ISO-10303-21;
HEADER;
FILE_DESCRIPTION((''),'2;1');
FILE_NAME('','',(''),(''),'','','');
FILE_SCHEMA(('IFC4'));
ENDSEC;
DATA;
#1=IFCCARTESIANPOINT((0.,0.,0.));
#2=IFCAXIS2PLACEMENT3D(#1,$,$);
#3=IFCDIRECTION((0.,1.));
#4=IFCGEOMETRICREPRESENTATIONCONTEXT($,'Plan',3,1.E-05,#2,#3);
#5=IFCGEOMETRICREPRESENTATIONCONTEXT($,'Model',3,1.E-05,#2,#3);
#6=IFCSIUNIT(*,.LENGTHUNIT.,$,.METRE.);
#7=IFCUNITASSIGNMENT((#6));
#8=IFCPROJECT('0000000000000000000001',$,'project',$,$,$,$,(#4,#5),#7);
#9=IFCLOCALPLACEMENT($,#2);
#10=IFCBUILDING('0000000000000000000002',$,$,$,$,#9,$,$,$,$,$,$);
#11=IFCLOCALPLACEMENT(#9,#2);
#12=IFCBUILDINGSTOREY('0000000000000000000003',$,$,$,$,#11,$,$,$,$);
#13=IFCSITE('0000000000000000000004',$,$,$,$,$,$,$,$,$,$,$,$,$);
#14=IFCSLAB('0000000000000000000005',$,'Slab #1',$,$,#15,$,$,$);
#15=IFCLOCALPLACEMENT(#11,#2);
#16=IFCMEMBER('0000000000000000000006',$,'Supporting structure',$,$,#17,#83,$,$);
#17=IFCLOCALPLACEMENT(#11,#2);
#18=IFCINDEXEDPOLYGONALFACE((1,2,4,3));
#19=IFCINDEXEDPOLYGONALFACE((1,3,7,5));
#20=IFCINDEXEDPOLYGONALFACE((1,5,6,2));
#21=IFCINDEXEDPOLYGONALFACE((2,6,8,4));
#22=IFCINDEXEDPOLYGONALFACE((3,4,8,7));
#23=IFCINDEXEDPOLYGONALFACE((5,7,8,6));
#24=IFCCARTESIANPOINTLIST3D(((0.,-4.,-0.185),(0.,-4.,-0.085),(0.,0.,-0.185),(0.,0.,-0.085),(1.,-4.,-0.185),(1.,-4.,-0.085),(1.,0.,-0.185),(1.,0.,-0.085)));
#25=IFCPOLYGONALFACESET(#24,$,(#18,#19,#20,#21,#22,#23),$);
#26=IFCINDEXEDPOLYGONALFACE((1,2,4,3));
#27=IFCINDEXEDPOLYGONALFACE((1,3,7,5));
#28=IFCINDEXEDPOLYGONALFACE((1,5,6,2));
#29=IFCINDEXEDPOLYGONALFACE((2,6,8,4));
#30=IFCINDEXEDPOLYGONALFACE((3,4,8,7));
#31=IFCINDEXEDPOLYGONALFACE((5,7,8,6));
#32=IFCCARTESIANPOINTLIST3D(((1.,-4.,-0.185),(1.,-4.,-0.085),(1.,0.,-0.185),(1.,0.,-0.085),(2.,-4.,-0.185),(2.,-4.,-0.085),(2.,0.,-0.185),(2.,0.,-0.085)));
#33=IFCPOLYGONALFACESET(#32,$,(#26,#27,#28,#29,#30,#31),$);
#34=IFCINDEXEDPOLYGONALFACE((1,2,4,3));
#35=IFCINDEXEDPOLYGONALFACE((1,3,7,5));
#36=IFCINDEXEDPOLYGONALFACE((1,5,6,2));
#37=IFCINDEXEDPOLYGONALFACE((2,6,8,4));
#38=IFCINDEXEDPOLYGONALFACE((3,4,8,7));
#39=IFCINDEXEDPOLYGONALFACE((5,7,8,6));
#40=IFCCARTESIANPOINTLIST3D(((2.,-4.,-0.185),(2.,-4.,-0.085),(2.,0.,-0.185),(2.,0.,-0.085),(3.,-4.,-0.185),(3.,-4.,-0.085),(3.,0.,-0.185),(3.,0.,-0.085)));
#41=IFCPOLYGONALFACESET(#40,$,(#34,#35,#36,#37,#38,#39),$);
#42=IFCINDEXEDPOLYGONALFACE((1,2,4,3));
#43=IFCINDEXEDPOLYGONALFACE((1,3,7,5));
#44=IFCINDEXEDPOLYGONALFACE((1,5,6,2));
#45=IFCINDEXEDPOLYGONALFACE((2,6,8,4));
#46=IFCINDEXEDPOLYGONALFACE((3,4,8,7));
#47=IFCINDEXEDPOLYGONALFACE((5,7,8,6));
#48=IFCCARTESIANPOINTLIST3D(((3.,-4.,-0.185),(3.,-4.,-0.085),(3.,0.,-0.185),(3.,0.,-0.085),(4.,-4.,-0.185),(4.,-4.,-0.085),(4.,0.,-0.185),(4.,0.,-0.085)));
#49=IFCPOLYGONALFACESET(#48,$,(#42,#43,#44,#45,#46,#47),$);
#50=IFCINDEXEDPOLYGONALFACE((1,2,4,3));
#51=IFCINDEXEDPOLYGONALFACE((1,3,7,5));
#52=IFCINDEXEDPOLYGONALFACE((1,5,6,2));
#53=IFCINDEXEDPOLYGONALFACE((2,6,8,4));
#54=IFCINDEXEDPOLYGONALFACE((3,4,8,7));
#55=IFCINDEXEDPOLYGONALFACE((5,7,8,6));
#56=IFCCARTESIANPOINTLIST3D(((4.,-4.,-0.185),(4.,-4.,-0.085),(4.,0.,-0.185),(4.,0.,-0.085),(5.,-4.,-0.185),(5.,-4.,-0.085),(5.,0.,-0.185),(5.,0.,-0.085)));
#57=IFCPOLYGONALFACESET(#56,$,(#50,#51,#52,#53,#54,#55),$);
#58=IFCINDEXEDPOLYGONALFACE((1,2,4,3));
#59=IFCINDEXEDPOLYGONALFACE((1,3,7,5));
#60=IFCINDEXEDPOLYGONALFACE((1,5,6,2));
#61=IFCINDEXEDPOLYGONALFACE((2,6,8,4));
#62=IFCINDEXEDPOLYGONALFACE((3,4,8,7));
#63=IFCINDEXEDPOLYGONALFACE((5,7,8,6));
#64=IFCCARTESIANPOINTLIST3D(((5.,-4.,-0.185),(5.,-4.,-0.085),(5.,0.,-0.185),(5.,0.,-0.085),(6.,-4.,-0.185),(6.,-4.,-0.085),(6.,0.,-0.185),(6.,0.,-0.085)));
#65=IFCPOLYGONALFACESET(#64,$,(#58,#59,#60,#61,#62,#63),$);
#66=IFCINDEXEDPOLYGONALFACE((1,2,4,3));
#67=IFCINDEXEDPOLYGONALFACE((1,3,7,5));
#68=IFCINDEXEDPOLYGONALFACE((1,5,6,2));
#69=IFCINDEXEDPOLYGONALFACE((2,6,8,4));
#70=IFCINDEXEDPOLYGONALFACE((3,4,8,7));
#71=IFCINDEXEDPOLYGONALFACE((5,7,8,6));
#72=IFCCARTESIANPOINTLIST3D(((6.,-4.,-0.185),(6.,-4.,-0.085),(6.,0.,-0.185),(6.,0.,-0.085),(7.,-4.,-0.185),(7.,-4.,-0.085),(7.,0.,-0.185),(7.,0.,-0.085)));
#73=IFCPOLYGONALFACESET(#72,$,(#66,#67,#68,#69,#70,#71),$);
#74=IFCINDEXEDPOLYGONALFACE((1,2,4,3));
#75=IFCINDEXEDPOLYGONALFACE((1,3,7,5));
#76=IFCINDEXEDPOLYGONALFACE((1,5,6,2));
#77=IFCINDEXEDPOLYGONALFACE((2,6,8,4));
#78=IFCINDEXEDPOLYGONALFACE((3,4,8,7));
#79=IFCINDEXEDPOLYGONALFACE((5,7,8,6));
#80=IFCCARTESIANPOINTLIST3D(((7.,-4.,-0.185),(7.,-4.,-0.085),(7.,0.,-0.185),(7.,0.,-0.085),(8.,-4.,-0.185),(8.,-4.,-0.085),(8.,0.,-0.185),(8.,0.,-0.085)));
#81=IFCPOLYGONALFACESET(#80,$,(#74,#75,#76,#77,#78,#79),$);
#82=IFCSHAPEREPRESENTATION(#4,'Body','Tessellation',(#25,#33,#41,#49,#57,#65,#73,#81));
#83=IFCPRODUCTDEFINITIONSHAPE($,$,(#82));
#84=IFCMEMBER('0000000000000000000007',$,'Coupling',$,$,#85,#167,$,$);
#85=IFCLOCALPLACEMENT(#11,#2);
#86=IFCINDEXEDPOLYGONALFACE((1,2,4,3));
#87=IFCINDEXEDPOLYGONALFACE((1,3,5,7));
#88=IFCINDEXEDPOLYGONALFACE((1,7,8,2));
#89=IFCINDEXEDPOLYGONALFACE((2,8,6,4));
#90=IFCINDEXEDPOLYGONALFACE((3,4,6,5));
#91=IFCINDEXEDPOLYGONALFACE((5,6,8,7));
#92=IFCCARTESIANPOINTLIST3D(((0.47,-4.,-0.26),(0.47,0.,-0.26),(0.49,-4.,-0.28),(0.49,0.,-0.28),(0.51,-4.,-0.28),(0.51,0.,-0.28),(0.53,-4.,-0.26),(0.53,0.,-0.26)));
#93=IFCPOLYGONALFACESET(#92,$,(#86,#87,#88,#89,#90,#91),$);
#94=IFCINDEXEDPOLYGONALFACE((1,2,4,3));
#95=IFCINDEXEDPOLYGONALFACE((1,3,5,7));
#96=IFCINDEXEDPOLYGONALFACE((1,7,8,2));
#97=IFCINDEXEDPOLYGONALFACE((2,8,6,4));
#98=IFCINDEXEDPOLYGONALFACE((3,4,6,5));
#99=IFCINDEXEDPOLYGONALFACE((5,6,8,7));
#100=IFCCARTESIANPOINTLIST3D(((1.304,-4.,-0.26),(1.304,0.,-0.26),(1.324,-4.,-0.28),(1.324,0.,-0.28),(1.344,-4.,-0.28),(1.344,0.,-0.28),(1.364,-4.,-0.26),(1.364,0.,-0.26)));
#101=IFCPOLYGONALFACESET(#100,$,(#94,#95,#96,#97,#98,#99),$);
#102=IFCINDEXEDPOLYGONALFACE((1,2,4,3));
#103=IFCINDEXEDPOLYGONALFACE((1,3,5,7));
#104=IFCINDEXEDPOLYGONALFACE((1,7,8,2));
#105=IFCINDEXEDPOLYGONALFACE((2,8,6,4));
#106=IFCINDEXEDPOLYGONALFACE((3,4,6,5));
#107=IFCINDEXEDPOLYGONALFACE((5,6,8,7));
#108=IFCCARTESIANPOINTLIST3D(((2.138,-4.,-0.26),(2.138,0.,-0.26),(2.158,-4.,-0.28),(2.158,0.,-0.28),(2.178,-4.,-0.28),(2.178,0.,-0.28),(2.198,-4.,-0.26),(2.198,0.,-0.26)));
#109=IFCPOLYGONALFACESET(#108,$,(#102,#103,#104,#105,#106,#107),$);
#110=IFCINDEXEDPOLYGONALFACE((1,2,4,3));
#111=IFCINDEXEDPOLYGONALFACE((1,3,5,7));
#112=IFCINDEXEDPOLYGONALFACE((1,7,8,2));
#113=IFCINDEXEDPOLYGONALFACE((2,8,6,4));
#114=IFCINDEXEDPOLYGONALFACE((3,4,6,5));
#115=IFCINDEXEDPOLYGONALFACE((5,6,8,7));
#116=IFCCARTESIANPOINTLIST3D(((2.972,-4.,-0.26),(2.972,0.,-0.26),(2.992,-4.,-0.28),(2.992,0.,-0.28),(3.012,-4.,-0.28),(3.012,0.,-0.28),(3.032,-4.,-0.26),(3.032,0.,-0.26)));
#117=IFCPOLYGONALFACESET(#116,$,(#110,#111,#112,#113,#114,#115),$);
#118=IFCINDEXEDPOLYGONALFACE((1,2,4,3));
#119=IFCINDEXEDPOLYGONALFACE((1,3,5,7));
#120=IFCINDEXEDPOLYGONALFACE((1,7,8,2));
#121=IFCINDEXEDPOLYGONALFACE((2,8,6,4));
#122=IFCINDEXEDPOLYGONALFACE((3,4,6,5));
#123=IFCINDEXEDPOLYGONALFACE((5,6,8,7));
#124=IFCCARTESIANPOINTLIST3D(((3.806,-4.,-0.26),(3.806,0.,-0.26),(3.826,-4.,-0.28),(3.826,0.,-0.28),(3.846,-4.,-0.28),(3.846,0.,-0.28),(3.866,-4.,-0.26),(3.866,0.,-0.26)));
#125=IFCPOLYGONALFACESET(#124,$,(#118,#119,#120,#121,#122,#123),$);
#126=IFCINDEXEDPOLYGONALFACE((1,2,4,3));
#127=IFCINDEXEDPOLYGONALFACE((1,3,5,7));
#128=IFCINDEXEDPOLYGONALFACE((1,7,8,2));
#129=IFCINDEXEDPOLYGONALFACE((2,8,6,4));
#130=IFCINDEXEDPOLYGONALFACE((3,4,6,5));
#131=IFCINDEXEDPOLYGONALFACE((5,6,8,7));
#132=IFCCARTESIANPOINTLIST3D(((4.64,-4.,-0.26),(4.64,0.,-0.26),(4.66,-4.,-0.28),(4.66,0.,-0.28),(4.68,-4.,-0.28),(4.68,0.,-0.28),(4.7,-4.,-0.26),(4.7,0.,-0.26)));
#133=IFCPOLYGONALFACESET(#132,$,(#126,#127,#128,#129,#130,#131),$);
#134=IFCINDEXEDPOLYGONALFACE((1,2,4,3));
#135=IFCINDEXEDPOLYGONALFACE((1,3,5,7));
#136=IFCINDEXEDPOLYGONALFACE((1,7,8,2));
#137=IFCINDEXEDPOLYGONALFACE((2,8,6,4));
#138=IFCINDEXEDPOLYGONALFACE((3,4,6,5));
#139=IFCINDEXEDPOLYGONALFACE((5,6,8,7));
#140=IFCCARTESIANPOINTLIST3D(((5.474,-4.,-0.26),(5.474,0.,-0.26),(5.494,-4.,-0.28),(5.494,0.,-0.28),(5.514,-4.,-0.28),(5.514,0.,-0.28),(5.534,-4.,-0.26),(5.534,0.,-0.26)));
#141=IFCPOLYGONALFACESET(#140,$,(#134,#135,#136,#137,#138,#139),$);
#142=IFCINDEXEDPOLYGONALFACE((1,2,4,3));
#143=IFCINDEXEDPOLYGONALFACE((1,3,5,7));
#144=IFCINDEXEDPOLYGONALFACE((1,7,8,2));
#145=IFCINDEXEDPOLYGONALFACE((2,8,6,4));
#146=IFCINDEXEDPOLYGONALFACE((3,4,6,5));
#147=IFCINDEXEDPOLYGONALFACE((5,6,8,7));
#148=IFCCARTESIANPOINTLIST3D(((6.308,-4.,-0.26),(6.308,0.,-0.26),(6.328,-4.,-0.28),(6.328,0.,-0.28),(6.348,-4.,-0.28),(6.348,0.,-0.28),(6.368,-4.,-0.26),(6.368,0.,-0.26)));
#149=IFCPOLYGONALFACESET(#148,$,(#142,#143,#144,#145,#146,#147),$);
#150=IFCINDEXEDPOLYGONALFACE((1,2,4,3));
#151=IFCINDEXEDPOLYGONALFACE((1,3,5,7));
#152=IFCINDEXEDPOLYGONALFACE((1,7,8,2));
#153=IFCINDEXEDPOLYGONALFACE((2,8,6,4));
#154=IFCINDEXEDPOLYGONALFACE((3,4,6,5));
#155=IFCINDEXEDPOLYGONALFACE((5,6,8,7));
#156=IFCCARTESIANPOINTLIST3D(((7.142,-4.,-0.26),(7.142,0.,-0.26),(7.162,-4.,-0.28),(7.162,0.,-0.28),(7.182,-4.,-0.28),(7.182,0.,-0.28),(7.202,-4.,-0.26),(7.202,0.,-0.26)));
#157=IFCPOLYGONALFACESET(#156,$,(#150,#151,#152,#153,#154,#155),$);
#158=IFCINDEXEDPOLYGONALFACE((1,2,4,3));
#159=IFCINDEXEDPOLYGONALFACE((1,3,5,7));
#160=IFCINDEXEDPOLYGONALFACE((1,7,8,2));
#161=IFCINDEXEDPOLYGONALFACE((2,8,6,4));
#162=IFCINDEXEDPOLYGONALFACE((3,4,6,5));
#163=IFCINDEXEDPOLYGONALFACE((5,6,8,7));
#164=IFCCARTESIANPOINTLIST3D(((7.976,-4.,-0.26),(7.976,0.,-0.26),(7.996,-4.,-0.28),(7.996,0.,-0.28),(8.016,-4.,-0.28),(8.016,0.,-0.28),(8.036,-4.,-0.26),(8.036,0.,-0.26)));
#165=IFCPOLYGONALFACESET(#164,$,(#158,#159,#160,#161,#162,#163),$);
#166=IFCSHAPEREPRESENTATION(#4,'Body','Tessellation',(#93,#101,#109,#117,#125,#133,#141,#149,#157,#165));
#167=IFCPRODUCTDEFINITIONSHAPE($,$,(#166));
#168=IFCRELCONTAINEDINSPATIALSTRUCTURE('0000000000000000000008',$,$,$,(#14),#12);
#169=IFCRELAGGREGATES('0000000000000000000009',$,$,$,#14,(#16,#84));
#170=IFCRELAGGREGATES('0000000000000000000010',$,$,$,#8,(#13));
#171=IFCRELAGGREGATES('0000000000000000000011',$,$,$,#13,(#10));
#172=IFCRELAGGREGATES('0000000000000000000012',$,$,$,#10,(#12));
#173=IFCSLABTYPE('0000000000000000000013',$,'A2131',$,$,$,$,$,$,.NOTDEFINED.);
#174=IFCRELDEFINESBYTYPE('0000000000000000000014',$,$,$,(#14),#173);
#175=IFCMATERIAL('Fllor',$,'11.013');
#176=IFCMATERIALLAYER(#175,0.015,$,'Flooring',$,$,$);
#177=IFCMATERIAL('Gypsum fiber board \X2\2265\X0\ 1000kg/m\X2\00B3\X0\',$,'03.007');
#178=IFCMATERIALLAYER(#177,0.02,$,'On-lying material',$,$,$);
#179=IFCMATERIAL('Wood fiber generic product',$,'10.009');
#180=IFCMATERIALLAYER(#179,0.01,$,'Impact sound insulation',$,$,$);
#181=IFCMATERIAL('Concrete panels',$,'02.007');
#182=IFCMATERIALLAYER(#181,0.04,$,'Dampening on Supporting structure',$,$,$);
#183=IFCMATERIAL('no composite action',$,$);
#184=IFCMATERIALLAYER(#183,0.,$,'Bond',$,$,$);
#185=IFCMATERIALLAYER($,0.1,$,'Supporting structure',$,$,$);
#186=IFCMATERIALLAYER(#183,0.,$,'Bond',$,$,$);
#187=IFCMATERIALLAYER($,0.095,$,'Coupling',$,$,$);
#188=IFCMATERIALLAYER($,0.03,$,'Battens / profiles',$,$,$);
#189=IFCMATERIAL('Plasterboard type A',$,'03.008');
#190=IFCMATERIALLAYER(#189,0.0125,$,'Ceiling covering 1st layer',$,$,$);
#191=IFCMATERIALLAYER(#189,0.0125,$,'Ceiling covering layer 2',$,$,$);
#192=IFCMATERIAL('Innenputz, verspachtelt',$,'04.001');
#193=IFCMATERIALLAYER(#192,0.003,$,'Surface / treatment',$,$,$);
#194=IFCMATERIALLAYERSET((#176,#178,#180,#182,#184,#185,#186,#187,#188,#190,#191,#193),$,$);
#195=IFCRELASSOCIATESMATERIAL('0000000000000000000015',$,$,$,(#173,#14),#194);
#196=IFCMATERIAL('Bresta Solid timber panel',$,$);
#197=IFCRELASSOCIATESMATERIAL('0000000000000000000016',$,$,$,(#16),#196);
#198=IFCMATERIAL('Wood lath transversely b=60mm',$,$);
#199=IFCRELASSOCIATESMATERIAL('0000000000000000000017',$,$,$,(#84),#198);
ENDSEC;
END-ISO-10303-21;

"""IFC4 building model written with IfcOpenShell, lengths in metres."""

from ifc_helpers import new_model, si_unit, direction, frame, frame_2d, origin, place, context, project, spatial, polyline, rectangle, outline, extrude, material, layer, layer_set, type_object, element, aggregate, save


model = new_model("IFC4")

# Units and contexts
plan_context = context("Plan", 3, precision=1e-05, world=origin(), true_north=direction((0.0, 1.0)))
model_context = context("Model", 3, precision=1e-05, world=origin(), true_north=direction((0.0, 1.0)))
ifc_project = project(units=[si_unit("LENGTHUNIT", "METRE")], contexts=[plan_context, model_context])

# Site, building, storey
site = spatial("IfcSite", under=ifc_project)
building_placement = place(None, origin())
building = spatial("IfcBuilding", under=site, at=building_placement)
storey_placement = place(building_placement, origin())
storey = spatial("IfcBuildingStorey", under=building, at=storey_placement)

# Slab, members
ifc_material_1 = material(Name="Fllor", Category="11.013")
ifc_layer_1 = layer(ifc_material_1, 0.015, Name="Flooring")
ifc_material_2 = material(Name="Gypsum fiber board ≥ 1000kg/m³", Category="03.007")
ifc_layer_2 = layer(ifc_material_2, 0.02, Name="On-lying material")
ifc_material_3 = material(Name="Wood fiber generic product", Category="10.009")
ifc_layer_3 = layer(ifc_material_3, 0.01, Name="Impact sound insulation")
ifc_material_4 = material(Name="Concrete panels", Category="02.007")
ifc_layer_4 = layer(ifc_material_4, 0.04, Name="Dampening on Supporting structure")
ifc_material_5 = material(Name="no composite action")
ifc_layer_5 = layer(ifc_material_5, 0.0, Name="Bond")
ifc_layer_6 = layer(None, 0.1, Name="Supporting structure")
ifc_layer_7 = layer(ifc_material_5, 0.0, Name="Bond")
ifc_layer_8 = layer(None, 0.095, Name="Coupling")
ifc_layer_9 = layer(None, 0.03, Name="Battens / profiles")
ifc_material_6 = material(Name="Plasterboard type A", Category="03.008")
ifc_layer_10 = layer(ifc_material_6, 0.0125, Name="Ceiling covering 1st layer")
ifc_layer_11 = layer(ifc_material_6, 0.0125, Name="Ceiling covering layer 2")
ifc_material_7 = material(Name="Innenputz, verspachtelt", Category="04.001")
ifc_layer_12 = layer(ifc_material_7, 0.003, Name="Surface / treatment")
ifc_layer_set = layer_set([ifc_layer_1, ifc_layer_2, ifc_layer_3, ifc_layer_4, ifc_layer_5, ifc_layer_6, ifc_layer_7, ifc_layer_8, ifc_layer_9, ifc_layer_10, ifc_layer_11, ifc_layer_12])
slab_type = type_object("IfcSlabType", Name="A2131", PredefinedType="NOTDEFINED", material=ifc_layer_set)
slab_placement = place(None, frame((0.0, 0.0, 0.0), z_axis=(0.0, 0.0, -1.0), x_axis=(1.0, 0.0, 0.0)))
slab = element("IfcSlab", 1, at=slab_placement, inside=storey, type_object=slab_type, material=ifc_layer_set, Name="Slab #1")
ifc_material_8 = material(Name="Bresta Solid timber panel")
member_1_placement = place(slab_placement, origin())
member_1 = element("IfcMember", 2, at=member_1_placement, material=ifc_material_8, Name="Supporting structure", context=plan_context, shape_type="SweptSolid", body=[
    extrude(rectangle(XDim=1.0, YDim=0.1, at=frame_2d((0.5, 0.05), x_axis=(1.0, 0.0))), frame((0.0, 4.0, 0.085), z_axis=(0.0, -1.0, 0.0), x_axis=(1.0, 0.0, 0.0)), (0.0, 0.0, 1.0), 4.0),
    extrude(rectangle(XDim=1.0, YDim=0.1, at=frame_2d((0.5, 0.05), x_axis=(1.0, 0.0))), frame((1.0, 4.0, 0.085), z_axis=(0.0, -1.0, 0.0), x_axis=(1.0, 0.0, 0.0)), (0.0, 0.0, 1.0), 4.0),
    extrude(rectangle(XDim=1.0, YDim=0.1, at=frame_2d((0.5, 0.05), x_axis=(1.0, 0.0))), frame((2.0, 4.0, 0.085), z_axis=(0.0, -1.0, 0.0), x_axis=(1.0, 0.0, 0.0)), (0.0, 0.0, 1.0), 4.0),
    extrude(rectangle(XDim=1.0, YDim=0.1, at=frame_2d((0.5, 0.05), x_axis=(1.0, 0.0))), frame((3.0, 4.0, 0.085), z_axis=(0.0, -1.0, 0.0), x_axis=(1.0, 0.0, 0.0)), (0.0, 0.0, 1.0), 4.0),
    extrude(rectangle(XDim=1.0, YDim=0.1, at=frame_2d((0.5, 0.05), x_axis=(1.0, 0.0))), frame((4.0, 4.0, 0.085), z_axis=(0.0, -1.0, 0.0), x_axis=(1.0, 0.0, 0.0)), (0.0, 0.0, 1.0), 4.0),
    extrude(rectangle(XDim=1.0, YDim=0.1, at=frame_2d((0.5, 0.05), x_axis=(1.0, 0.0))), frame((5.0, 4.0, 0.085), z_axis=(0.0, -1.0, 0.0), x_axis=(1.0, 0.0, 0.0)), (0.0, 0.0, 1.0), 4.0),
    extrude(rectangle(XDim=1.0, YDim=0.1, at=frame_2d((0.5, 0.05), x_axis=(1.0, 0.0))), frame((6.0, 4.0, 0.085), z_axis=(0.0, -1.0, 0.0), x_axis=(1.0, 0.0, 0.0)), (0.0, 0.0, 1.0), 4.0),
    extrude(rectangle(XDim=1.0, YDim=0.1, at=frame_2d((0.5, 0.05), x_axis=(1.0, 0.0))), frame((7.0, 4.0, 0.085), z_axis=(0.0, -1.0, 0.0), x_axis=(1.0, 0.0, 0.0)), (0.0, 0.0, 1.0), 4.0),
])
ifc_material_9 = material(Name="Wood lath transversely b=60mm")
member_2_placement = place(slab_placement, origin())
member_2 = element("IfcMember", 3, at=member_2_placement, material=ifc_material_9, Name="Coupling", context=plan_context, shape_type="SweptSolid", body=[
    extrude(outline(polyline([(0.0, 0.0), (0.06, 0.0), (0.04, 0.02), (0.02, 0.02), (0.0, 0.0)])), frame((0.47, 4.0, 0.26), z_axis=(0.0, -1.0, 0.0), x_axis=(1.0, 0.0, 0.0)), (0.0, 0.0, 1.0), 4.0),
    extrude(outline(polyline([(0.0, 0.0), (0.06, 0.0), (0.04, 0.02), (0.02, 0.02), (0.0, 0.0)])), frame((1.304, 4.0, 0.26), z_axis=(0.0, -1.0, 0.0), x_axis=(1.0, 0.0, 0.0)), (0.0, 0.0, 1.0), 4.0),
    extrude(outline(polyline([(0.0, 0.0), (0.06, 0.0), (0.04, 0.02), (0.02, 0.02), (0.0, 0.0)])), frame((2.138, 4.0, 0.26), z_axis=(0.0, -1.0, 0.0), x_axis=(1.0, 0.0, 0.0)), (0.0, 0.0, 1.0), 4.0),
    extrude(outline(polyline([(0.0, 0.0), (0.06, 0.0), (0.04, 0.02), (0.02, 0.02), (0.0, 0.0)])), frame((2.972, 4.0, 0.26), z_axis=(0.0, -1.0, 0.0), x_axis=(1.0, 0.0, 0.0)), (0.0, 0.0, 1.0), 4.0),
    extrude(outline(polyline([(0.0, 0.0), (0.06, 0.0), (0.04, 0.02), (0.02, 0.02), (0.0, 0.0)])), frame((3.806, 4.0, 0.26), z_axis=(0.0, -1.0, 0.0), x_axis=(1.0, 0.0, 0.0)), (0.0, 0.0, 1.0), 4.0),
    extrude(outline(polyline([(0.0, 0.0), (0.06, 0.0), (0.04, 0.02), (0.02, 0.02), (0.0, 0.0)])), frame((4.64, 4.0, 0.26), z_axis=(0.0, -1.0, 0.0), x_axis=(1.0, 0.0, 0.0)), (0.0, 0.0, 1.0), 4.0),
    extrude(outline(polyline([(0.0, 0.0), (0.06, 0.0), (0.04, 0.02), (0.02, 0.02), (0.0, 0.0)])), frame((5.474, 4.0, 0.26), z_axis=(0.0, -1.0, 0.0), x_axis=(1.0, 0.0, 0.0)), (0.0, 0.0, 1.0), 4.0),
    extrude(outline(polyline([(0.0, 0.0), (0.06, 0.0), (0.04, 0.02), (0.02, 0.02), (0.0, 0.0)])), frame((6.308, 4.0, 0.26), z_axis=(0.0, -1.0, 0.0), x_axis=(1.0, 0.0, 0.0)), (0.0, 0.0, 1.0), 4.0),
    extrude(outline(polyline([(0.0, 0.0), (0.06, 0.0), (0.04, 0.02), (0.02, 0.02), (0.0, 0.0)])), frame((7.142, 4.0, 0.26), z_axis=(0.0, -1.0, 0.0), x_axis=(1.0, 0.0, 0.0)), (0.0, 0.0, 1.0), 4.0),
    extrude(outline(polyline([(0.0, 0.0), (0.06, 0.0), (0.04, 0.02), (0.02, 0.02), (0.0, 0.0)])), frame((7.976, 4.0, 0.26), z_axis=(0.0, -1.0, 0.0), x_axis=(1.0, 0.0, 0.0)), (0.0, 0.0, 1.0), 4.0),
])
aggregate(slab, [member_1, member_2])

save(model, "model.ifc")
